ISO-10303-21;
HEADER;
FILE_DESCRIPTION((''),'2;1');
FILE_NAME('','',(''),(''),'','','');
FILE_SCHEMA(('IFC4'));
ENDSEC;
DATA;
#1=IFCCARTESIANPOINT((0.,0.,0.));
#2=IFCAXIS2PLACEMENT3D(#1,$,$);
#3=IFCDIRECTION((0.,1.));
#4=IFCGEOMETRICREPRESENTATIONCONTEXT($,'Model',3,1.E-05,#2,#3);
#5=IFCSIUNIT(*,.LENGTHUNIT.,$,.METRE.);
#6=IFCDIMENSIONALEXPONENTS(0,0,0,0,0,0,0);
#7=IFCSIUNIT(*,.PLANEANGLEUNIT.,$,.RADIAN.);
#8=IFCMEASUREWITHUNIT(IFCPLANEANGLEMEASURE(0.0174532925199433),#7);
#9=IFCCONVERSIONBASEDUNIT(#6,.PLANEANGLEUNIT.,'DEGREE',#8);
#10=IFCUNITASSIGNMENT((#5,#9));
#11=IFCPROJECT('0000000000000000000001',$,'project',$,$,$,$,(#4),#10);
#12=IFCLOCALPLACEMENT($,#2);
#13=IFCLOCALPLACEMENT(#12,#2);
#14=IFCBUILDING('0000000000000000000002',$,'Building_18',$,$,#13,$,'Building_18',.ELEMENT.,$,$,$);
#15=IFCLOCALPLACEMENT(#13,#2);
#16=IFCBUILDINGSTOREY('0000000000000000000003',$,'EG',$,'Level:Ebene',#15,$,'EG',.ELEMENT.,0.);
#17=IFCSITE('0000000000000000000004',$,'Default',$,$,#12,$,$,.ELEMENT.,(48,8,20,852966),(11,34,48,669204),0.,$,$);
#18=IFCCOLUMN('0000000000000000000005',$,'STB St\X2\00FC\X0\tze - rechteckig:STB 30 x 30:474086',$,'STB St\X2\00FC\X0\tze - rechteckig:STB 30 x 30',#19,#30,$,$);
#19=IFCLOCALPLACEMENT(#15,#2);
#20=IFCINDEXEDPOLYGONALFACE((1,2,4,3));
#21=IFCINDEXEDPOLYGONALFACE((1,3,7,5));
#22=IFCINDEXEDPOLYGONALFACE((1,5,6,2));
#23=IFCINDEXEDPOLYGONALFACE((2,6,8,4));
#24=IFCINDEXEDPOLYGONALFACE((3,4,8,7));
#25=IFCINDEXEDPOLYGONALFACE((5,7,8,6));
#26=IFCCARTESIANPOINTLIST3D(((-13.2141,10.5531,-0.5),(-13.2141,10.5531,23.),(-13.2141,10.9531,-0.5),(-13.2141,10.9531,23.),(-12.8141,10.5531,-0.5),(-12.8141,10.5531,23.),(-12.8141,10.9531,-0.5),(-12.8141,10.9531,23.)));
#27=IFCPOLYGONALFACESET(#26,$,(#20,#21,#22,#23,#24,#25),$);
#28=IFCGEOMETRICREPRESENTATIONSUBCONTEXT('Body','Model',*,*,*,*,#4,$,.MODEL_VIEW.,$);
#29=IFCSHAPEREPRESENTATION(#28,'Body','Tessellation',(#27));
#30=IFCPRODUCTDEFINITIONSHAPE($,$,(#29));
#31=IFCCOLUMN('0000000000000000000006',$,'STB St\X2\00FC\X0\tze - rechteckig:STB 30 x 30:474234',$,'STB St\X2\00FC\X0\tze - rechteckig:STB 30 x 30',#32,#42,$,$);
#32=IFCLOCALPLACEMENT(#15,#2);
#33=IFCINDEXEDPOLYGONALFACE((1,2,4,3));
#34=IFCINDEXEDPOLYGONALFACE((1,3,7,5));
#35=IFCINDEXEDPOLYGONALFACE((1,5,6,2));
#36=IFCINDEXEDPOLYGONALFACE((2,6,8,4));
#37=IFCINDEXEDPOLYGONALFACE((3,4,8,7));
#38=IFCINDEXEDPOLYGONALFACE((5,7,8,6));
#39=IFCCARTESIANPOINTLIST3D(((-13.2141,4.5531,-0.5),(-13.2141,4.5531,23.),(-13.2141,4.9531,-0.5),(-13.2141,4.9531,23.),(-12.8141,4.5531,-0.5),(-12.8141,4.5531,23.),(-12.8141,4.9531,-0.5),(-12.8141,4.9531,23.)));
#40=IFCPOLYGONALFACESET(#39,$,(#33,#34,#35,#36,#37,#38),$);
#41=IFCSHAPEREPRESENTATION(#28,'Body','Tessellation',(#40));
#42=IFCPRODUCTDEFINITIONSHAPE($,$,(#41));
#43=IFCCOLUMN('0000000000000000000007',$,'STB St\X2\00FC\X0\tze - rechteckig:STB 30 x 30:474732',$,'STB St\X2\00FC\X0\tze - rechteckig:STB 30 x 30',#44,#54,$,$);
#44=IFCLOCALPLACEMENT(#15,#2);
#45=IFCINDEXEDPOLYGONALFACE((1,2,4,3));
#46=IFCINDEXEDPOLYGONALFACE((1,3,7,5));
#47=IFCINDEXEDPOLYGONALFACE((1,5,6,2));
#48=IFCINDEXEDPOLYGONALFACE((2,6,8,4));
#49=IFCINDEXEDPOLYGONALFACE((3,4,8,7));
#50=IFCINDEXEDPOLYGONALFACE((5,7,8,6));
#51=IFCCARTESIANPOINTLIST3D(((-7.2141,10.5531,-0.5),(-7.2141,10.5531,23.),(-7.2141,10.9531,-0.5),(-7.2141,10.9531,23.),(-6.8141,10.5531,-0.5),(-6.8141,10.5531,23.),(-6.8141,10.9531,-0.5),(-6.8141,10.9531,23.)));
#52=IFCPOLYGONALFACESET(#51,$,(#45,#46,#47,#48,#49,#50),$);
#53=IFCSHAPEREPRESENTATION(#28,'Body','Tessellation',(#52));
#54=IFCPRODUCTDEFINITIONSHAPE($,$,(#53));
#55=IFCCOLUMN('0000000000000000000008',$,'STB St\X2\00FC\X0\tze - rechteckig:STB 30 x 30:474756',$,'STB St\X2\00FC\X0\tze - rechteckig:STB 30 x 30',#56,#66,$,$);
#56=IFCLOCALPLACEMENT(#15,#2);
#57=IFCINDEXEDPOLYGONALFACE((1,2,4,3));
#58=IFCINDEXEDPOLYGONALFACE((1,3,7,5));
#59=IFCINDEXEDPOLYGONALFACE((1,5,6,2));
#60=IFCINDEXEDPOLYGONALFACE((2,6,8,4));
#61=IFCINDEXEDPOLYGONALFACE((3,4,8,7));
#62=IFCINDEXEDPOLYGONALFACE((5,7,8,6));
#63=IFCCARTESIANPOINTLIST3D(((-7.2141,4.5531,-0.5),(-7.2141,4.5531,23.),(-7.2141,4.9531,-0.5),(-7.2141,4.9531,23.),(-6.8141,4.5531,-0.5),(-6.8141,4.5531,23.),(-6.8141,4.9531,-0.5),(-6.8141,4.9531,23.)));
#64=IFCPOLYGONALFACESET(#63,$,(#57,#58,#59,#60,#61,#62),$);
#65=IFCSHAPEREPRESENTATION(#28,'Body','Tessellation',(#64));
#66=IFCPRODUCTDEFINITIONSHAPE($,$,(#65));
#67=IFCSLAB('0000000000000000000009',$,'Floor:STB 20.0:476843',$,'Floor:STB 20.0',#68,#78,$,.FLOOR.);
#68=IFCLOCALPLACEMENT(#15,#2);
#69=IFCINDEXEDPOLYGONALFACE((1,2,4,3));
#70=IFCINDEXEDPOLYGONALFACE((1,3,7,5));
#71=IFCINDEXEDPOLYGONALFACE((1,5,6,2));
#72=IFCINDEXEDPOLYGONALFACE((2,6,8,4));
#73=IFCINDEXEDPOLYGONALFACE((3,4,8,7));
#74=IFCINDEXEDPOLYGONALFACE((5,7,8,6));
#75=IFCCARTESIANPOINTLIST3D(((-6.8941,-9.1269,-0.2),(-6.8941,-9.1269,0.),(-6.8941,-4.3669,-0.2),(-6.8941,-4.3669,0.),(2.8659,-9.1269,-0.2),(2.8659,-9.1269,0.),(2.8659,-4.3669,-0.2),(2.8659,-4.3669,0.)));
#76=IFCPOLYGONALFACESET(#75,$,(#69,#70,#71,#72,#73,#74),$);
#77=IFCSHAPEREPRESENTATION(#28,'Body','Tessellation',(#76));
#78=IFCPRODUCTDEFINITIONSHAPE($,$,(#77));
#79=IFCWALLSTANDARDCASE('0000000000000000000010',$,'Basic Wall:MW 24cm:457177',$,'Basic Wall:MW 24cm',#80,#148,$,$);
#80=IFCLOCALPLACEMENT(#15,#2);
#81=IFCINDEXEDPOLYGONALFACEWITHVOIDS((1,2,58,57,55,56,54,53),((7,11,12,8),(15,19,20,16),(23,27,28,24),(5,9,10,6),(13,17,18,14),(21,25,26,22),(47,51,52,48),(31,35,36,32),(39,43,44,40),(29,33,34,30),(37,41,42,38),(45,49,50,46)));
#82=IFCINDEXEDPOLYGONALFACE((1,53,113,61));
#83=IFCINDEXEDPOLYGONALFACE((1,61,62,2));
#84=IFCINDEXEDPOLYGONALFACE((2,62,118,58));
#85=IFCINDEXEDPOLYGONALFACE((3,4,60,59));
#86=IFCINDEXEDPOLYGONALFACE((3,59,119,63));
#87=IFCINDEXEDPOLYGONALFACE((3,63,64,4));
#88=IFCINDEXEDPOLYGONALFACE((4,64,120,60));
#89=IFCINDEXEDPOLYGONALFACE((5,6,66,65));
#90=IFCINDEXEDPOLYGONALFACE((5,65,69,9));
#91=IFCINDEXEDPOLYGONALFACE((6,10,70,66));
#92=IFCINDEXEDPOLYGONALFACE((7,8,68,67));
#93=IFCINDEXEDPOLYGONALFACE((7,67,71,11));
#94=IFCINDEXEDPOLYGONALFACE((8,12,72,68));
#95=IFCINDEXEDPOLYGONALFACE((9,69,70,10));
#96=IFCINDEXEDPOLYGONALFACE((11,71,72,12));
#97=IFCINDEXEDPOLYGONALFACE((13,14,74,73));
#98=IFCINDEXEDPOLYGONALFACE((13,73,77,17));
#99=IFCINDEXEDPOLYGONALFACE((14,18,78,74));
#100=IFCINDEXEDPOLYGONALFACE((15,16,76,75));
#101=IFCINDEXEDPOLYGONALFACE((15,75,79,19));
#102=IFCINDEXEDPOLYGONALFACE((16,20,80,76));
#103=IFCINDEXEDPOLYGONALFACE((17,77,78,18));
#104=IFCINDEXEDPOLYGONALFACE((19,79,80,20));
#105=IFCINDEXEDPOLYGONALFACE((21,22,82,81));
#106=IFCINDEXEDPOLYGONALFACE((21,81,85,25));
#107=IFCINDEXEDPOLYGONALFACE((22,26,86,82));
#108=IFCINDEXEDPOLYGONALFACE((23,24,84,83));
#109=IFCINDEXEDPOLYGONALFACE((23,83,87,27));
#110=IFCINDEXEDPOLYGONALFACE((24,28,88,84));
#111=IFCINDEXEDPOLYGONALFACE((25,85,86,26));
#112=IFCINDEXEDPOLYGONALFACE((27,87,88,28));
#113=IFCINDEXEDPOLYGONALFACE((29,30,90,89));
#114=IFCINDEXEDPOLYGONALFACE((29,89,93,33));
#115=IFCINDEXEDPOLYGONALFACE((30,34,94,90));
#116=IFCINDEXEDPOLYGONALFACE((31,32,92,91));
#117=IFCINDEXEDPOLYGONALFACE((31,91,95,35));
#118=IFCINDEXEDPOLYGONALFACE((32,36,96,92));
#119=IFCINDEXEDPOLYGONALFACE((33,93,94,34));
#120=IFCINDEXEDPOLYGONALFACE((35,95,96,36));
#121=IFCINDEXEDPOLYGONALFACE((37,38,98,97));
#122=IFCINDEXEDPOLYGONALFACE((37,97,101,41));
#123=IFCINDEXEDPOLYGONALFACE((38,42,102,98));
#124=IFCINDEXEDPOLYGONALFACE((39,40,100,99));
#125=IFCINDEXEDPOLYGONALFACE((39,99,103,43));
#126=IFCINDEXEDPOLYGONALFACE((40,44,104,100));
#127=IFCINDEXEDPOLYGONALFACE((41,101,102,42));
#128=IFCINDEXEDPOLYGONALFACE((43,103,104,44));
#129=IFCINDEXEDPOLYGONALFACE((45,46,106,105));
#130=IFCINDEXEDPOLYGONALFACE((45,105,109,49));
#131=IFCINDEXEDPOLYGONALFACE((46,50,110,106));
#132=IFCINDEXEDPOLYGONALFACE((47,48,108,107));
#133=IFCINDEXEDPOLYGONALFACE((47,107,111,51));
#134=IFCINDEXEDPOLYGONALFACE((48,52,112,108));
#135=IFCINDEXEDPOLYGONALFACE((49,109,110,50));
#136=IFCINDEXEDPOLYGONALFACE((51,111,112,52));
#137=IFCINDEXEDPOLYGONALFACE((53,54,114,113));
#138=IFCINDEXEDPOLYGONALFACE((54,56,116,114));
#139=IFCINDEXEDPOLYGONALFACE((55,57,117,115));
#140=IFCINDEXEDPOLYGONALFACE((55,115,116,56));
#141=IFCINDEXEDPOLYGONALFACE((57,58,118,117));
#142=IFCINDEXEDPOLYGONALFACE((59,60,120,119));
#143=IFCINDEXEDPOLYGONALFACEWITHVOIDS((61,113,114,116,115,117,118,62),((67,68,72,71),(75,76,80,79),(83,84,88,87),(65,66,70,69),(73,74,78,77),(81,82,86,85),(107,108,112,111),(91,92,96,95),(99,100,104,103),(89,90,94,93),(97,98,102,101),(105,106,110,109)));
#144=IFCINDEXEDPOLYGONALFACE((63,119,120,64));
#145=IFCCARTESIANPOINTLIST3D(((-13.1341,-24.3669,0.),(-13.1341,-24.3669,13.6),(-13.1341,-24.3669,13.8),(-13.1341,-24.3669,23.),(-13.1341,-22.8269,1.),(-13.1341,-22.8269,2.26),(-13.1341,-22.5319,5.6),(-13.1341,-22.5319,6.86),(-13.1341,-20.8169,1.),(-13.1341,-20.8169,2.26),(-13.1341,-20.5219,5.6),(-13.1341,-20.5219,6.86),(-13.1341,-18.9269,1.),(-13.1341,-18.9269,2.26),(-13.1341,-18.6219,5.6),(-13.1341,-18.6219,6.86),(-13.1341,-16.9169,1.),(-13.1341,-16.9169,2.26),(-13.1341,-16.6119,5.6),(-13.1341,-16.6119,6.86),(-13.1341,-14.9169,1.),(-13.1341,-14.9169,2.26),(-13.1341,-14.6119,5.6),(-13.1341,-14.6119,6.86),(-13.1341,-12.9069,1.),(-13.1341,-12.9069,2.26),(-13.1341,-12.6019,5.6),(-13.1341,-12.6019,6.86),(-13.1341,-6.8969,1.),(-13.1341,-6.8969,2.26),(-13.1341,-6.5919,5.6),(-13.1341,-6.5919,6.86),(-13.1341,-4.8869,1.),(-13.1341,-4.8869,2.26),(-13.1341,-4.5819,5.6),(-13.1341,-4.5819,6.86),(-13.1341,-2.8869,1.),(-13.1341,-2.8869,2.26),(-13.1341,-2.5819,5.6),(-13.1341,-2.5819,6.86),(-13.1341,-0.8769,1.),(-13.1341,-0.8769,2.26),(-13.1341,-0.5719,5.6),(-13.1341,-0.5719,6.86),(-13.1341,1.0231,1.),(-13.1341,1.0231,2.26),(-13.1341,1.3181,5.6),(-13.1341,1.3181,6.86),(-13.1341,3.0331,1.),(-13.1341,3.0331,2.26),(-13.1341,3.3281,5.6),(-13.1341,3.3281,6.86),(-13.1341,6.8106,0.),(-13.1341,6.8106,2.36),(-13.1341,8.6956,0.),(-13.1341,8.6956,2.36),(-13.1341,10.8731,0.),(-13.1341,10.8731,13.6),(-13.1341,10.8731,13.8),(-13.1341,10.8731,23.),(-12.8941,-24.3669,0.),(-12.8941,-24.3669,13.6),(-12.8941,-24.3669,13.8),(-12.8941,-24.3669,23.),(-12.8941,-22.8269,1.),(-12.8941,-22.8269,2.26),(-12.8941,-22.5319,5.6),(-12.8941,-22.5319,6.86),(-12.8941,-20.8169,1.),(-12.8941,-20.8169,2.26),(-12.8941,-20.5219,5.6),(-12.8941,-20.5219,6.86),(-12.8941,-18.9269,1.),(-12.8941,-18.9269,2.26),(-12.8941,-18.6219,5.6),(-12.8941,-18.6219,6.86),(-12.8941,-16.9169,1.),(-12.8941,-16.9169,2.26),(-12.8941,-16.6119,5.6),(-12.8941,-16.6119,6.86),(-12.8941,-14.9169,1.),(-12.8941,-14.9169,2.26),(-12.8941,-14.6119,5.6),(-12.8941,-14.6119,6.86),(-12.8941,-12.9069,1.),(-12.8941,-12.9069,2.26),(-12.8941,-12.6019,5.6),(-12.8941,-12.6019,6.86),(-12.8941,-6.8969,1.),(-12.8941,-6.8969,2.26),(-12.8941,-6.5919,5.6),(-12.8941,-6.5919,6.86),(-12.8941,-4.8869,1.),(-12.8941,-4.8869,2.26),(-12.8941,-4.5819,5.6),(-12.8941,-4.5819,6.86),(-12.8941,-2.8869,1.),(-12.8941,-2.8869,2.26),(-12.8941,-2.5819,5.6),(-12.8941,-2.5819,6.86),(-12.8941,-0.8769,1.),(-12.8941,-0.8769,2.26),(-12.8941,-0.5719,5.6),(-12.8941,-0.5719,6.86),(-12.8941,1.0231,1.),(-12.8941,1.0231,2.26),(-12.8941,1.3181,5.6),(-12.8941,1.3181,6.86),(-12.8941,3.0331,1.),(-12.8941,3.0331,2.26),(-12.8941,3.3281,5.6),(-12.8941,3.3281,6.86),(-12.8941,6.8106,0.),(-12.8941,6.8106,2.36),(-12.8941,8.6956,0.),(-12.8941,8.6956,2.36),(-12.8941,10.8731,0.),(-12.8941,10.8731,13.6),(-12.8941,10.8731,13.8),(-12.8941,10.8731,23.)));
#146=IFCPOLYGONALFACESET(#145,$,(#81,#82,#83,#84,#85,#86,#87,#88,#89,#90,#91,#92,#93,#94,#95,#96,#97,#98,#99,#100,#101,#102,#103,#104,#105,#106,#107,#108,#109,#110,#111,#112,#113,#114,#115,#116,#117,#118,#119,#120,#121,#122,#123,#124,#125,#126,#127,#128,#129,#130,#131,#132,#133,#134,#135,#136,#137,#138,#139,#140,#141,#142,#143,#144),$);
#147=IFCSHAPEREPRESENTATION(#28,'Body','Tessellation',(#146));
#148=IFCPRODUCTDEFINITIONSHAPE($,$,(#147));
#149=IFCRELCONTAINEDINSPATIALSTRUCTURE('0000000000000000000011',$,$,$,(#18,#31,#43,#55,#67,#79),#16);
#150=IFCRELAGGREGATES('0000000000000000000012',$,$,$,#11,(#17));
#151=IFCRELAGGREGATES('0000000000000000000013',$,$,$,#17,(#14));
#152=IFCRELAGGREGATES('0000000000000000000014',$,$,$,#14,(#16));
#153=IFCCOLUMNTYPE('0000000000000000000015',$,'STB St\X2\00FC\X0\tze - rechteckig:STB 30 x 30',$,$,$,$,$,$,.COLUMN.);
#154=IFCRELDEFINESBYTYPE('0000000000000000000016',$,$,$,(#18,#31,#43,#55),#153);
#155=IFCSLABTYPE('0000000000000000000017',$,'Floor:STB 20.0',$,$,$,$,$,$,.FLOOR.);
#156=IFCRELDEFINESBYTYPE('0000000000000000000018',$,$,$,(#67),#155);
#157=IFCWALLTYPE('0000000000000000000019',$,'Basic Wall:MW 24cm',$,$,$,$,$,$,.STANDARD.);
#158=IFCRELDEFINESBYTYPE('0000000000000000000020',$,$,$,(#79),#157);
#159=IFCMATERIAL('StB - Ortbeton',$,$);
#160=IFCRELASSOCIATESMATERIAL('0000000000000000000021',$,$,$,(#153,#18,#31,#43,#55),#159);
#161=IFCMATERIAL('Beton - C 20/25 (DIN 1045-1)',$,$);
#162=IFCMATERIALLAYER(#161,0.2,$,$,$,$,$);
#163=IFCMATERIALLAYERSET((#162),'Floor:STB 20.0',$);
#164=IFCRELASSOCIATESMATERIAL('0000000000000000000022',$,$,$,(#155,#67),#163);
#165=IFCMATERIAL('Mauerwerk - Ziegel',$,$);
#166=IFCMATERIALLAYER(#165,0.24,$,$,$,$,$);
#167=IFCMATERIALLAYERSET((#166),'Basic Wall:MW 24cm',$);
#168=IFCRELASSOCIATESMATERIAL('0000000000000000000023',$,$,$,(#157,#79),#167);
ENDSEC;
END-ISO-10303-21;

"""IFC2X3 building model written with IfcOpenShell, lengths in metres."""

from ifc_helpers import new_model, entity, si_unit, converted_unit, direction, frame, frame_2d, origin, origin_2d_with_axis, place, context, subcontext, project, spatial, rectangle, extrude, source, transform, mapped, material, layer, layer_set, layer_usage, type_object, type_shapes, element, save


model = new_model("IFC2X3")

# Units and contexts
model_context = context("Model", 3, precision=1e-05, world=origin(), true_north=direction((0.0, 1.0)))
body_context = subcontext(model_context, "Body", "Model", "MODEL_VIEW")
ifc_project = project(units=[si_unit("LENGTHUNIT", "METRE"), converted_unit("PLANEANGLEUNIT", "DEGREE", entity("IfcPlaneAngleMeasure", 0.0174532925199433), si_unit("PLANEANGLEUNIT", "RADIAN"), dimensions=[0, 0, 0, 0, 0, 0, 0])], contexts=[model_context])

# Site, building, storey
site_placement = place(None, origin())
site = spatial("IfcSite", under=ifc_project, at=site_placement, Name="Default", CompositionType="ELEMENT", RefLatitude=(48, 8, 20, 852966), RefLongitude=(11, 34, 48, 669204), RefElevation=0.0)
building_placement = place(site_placement, origin())
building = spatial("IfcBuilding", under=site, at=building_placement, Name="Building_18", LongName="Building_18", CompositionType="ELEMENT")
storey_placement = place(building_placement, origin())
storey = spatial("IfcBuildingStorey", under=building, at=storey_placement, Name="EG", ObjectType="Level:Ebene", LongName="EG", CompositionType="ELEMENT", Elevation=0.0)

# Columns
ifc_material_1 = material(Name="StB - Ortbeton")
column_type = type_object("IfcColumnType", Name="STB Stütze - rechteckig:STB 30 x 30", PredefinedType="COLUMN", material=ifc_material_1)
shared_shape_1 = source(origin(), body_context, "Body", "SweptSolid", [
    extrude(rectangle(XDim=0.4, YDim=0.4, at=origin_2d_with_axis()), frame((0.0, 0.0, -0.5), z_axis=(0.0, 0.0, 1.0), x_axis=(-1.0, 0.0, 0.0)), (0.0, 0.0, 1.0), 23.5),
])
type_shapes(column_type, [shared_shape_1])
for number, where, name in (
    (1, (-13.0141, 10.7531, 0.0), "STB Stütze - rechteckig:STB 30 x 30:474086"),
    (2, (-13.0141, 4.7531, 0.0), "STB Stütze - rechteckig:STB 30 x 30:474234"),
    (3, (-7.0141, 10.7531, 0.0), "STB Stütze - rechteckig:STB 30 x 30:474732"),
    (4, (-7.0141, 4.7531, 0.0), "STB Stütze - rechteckig:STB 30 x 30:474756"),
):
    element("IfcColumn", number, at=place(storey_placement, frame(where)), inside=storey, type_object=column_type, material=ifc_material_1, Name=name, ObjectType="STB Stütze - rechteckig:STB 30 x 30", context=body_context, shape_type="MappedRepresentation", body=[
        mapped(shared_shape_1, transform((0.0, 0.0, 0.0), scale=1.0)),
    ])

# Slab
ifc_material_2 = material(Name="Beton - C 20/25 (DIN 1045-1)")
ifc_layer_1 = layer(ifc_material_2, 0.2)
ifc_layer_set_1 = layer_set([ifc_layer_1], Name="Floor:STB 20.0")
ifc_layer_usage_1 = layer_usage(ifc_layer_set_1, "AXIS3", "POSITIVE", 0.0)
slab_type_1 = type_object("IfcSlabType", Name="Floor:STB 20.0", PredefinedType="FLOOR", material=ifc_layer_set_1)
slab_1_placement = place(storey_placement, origin())
element("IfcSlab", 5, at=slab_1_placement, inside=storey, type_object=slab_type_1, material=ifc_layer_usage_1, Name="Floor:STB 20.0:476843", ObjectType="Floor:STB 20.0", PredefinedType="FLOOR", context=body_context, shape_type="SweptSolid", body=[
    extrude(rectangle(XDim=4.76, YDim=9.76, at=frame_2d((0.0, 0.0), x_axis=(1.0, 0.0))), frame((-2.0141, -6.7469, 0.0), z_axis=(0.0, 0.0, -1.0), x_axis=(0.0, 1.0, 0.0)), (0.0, 0.0, 1.0), 0.2),
])

# Wall, openings
ifc_material_3 = material(Name="Mauerwerk - Ziegel")
ifc_layer_2 = layer(ifc_material_3, 0.24)
ifc_layer_set_2 = layer_set([ifc_layer_2], Name="Basic Wall:MW 24cm")
ifc_layer_usage_2 = layer_usage(ifc_layer_set_2, "AXIS2", "NEGATIVE", 0.12)
wall_type = type_object("IfcWallType", Name="Basic Wall:MW 24cm", PredefinedType="STANDARD", material=ifc_layer_set_2)
wall_1_placement = place(storey_placement, frame((-13.0141, 10.8731, 0.0), z_axis=(0.0, 0.0, 1.0), x_axis=(0.0, -1.0, 0.0)))
wall_1 = element("IfcWallStandardCase", 6, at=wall_1_placement, inside=storey, type_object=wall_type, material=ifc_layer_usage_2, Name="Basic Wall:MW 24cm:457177", ObjectType="Basic Wall:MW 24cm", context=body_context, shape_type="SweptSolid", body=[
    extrude(rectangle(XDim=35.24, YDim=0.24, at=frame_2d((17.62, 0.0), x_axis=(-1.0, 0.0))), origin(), (0.0, 0.0, 1.0), 23.0),
])
opening_1_placement = place(storey_placement, frame((-13.0141, 10.8731, 0.0), z_axis=(0.0, 0.0, 1.0), x_axis=(0.0, -1.0, 0.0)))
element("IfcOpeningElement", 7, at=opening_1_placement, cuts=wall_1, ObjectType="Opening", context=body_context, shape_type="SweptSolid", body=[
    extrude(rectangle(XDim=35.24, YDim=0.24, at=frame_2d((0.0, -0.04), x_axis=(1.0, 0.0))), frame((17.62, 0.04, 13.6)), (0.0, 0.0, 1.0), 0.2),
])
opening_2_placement = place(wall_1_placement, frame((2.1775, -0.12, 0.0)))
element("IfcOpeningElement", 8, at=opening_2_placement, cuts=wall_1, ObjectType="Opening", context=body_context, shape_type="SweptSolid", body=[
    extrude(rectangle(XDim=2.36, YDim=1.885, at=frame_2d((1.18, 0.9425), x_axis=(1.0, 0.0))), frame((0.0, 0.0, 0.0), z_axis=(0.0, 1.0, 0.0), x_axis=(0.0, 0.0, 1.0)), (0.0, 0.0, 1.0), 0.24),
])
opening_3_placement = place(wall_1_placement, frame((9.85, 0.12, 1.0)))
element("IfcOpeningElement", 9, at=opening_3_placement, cuts=wall_1, ObjectType="Opening", context=body_context, shape_type="SweptSolid", body=[
    extrude(rectangle(XDim=1.26, YDim=2.01, at=frame_2d((0.63, 1.005), x_axis=(1.0, 0.0))), frame((0.0, 0.0, 0.0), z_axis=(0.0, -1.0, 0.0), x_axis=(0.0, 0.0, 1.0)), (0.0, 0.0, 1.0), 0.24),
])
opening_4_placement = place(wall_1_placement, frame((13.76, 0.12, 1.0)))
element("IfcOpeningElement", 10, at=opening_4_placement, cuts=wall_1, ObjectType="Opening", context=body_context, shape_type="SweptSolid", body=[
    extrude(rectangle(XDim=1.26, YDim=2.01, at=frame_2d((0.63, 1.005), x_axis=(1.0, 0.0))), frame((0.0, 0.0, 0.0), z_axis=(0.0, -1.0, 0.0), x_axis=(0.0, 0.0, 1.0)), (0.0, 0.0, 1.0), 0.24),
])
opening_5_placement = place(wall_1_placement, frame((17.77, 0.12, 1.0)))
element("IfcOpeningElement", 11, at=opening_5_placement, cuts=wall_1, ObjectType="Opening", context=body_context, shape_type="SweptSolid", body=[
    extrude(rectangle(XDim=1.26, YDim=2.01, at=frame_2d((0.63, 1.005), x_axis=(1.0, 0.0))), frame((0.0, 0.0, 0.0), z_axis=(0.0, -1.0, 0.0), x_axis=(0.0, 0.0, 1.0)), (0.0, 0.0, 1.0), 0.24),
])
opening_6_placement = place(wall_1_placement, frame((25.79, 0.12, 1.0)))
element("IfcOpeningElement", 12, at=opening_6_placement, cuts=wall_1, ObjectType="Opening", context=body_context, shape_type="SweptSolid", body=[
    extrude(rectangle(XDim=1.26, YDim=2.01, at=frame_2d((0.63, 1.005), x_axis=(1.0, 0.0))), frame((0.0, 0.0, 0.0), z_axis=(0.0, -1.0, 0.0), x_axis=(0.0, 0.0, 1.0)), (0.0, 0.0, 1.0), 0.24),
])
opening_7_placement = place(wall_1_placement, frame((29.8, 0.12, 1.0)))
element("IfcOpeningElement", 13, at=opening_7_placement, cuts=wall_1, ObjectType="Opening", context=body_context, shape_type="SweptSolid", body=[
    extrude(rectangle(XDim=1.26, YDim=2.01, at=frame_2d((0.63, 1.005), x_axis=(1.0, 0.0))), frame((0.0, 0.0, 0.0), z_axis=(0.0, -1.0, 0.0), x_axis=(0.0, 0.0, 1.0)), (0.0, 0.0, 1.0), 0.24),
])
opening_8_placement = place(wall_1_placement, frame((33.7, 0.12, 1.0)))
element("IfcOpeningElement", 14, at=opening_8_placement, cuts=wall_1, ObjectType="Opening", context=body_context, shape_type="SweptSolid", body=[
    extrude(rectangle(XDim=1.26, YDim=2.01, at=frame_2d((0.63, 1.005), x_axis=(1.0, 0.0))), frame((0.0, 0.0, 0.0), z_axis=(0.0, -1.0, 0.0), x_axis=(0.0, 0.0, 1.0)), (0.0, 0.0, 1.0), 0.24),
])
opening_9_placement = place(wall_1_placement, frame((31.395, -0.12, 5.6)))
element("IfcOpeningElement", 15, at=opening_9_placement, cuts=wall_1, ObjectType="Opening", context=body_context, shape_type="SweptSolid", body=[
    extrude(rectangle(XDim=1.26, YDim=2.01, at=frame_2d((0.63, 1.005), x_axis=(1.0, 0.0))), frame((0.0, 0.0, 0.0), z_axis=(0.0, 1.0, 0.0), x_axis=(0.0, 0.0, 1.0)), (0.0, 0.0, 1.0), 0.24),
])
opening_10_placement = place(wall_1_placement, frame((27.485, -0.12, 5.6)))
element("IfcOpeningElement", 16, at=opening_10_placement, cuts=wall_1, ObjectType="Opening", context=body_context, shape_type="SweptSolid", body=[
    extrude(rectangle(XDim=1.26, YDim=2.01, at=frame_2d((0.63, 1.005), x_axis=(1.0, 0.0))), frame((0.0, 0.0, 0.0), z_axis=(0.0, 1.0, 0.0), x_axis=(0.0, 0.0, 1.0)), (0.0, 0.0, 1.0), 0.24),
])
opening_11_placement = place(wall_1_placement, frame((23.475, -0.12, 5.6)))
element("IfcOpeningElement", 17, at=opening_11_placement, cuts=wall_1, ObjectType="Opening", context=body_context, shape_type="SweptSolid", body=[
    extrude(rectangle(XDim=1.26, YDim=2.01, at=frame_2d((0.63, 1.005), x_axis=(1.0, 0.0))), frame((0.0, 0.0, 0.0), z_axis=(0.0, 1.0, 0.0), x_axis=(0.0, 0.0, 1.0)), (0.0, 0.0, 1.0), 0.24),
])
opening_12_placement = place(wall_1_placement, frame((15.455, -0.12, 5.6)))
element("IfcOpeningElement", 18, at=opening_12_placement, cuts=wall_1, ObjectType="Opening", context=body_context, shape_type="SweptSolid", body=[
    extrude(rectangle(XDim=1.26, YDim=2.01, at=frame_2d((0.63, 1.005), x_axis=(1.0, 0.0))), frame((0.0, 0.0, 0.0), z_axis=(0.0, 1.0, 0.0), x_axis=(0.0, 0.0, 1.0)), (0.0, 0.0, 1.0), 0.24),
])
opening_13_placement = place(wall_1_placement, frame((11.445, -0.12, 5.6)))
element("IfcOpeningElement", 19, at=opening_13_placement, cuts=wall_1, ObjectType="Opening", context=body_context, shape_type="SweptSolid", body=[
    extrude(rectangle(XDim=1.26, YDim=2.01, at=frame_2d((0.63, 1.005), x_axis=(1.0, 0.0))), frame((0.0, 0.0, 0.0), z_axis=(0.0, 1.0, 0.0), x_axis=(0.0, 0.0, 1.0)), (0.0, 0.0, 1.0), 0.24),
])
opening_14_placement = place(wall_1_placement, frame((7.545, -0.12, 5.6)))
element("IfcOpeningElement", 20, at=opening_14_placement, cuts=wall_1, ObjectType="Opening", context=body_context, shape_type="SweptSolid", body=[
    extrude(rectangle(XDim=1.26, YDim=2.01, at=frame_2d((0.63, 1.005), x_axis=(1.0, 0.0))), frame((0.0, 0.0, 0.0), z_axis=(0.0, 1.0, 0.0), x_axis=(0.0, 0.0, 1.0)), (0.0, 0.0, 1.0), 0.24),
])

save(model, "model.ifc")
